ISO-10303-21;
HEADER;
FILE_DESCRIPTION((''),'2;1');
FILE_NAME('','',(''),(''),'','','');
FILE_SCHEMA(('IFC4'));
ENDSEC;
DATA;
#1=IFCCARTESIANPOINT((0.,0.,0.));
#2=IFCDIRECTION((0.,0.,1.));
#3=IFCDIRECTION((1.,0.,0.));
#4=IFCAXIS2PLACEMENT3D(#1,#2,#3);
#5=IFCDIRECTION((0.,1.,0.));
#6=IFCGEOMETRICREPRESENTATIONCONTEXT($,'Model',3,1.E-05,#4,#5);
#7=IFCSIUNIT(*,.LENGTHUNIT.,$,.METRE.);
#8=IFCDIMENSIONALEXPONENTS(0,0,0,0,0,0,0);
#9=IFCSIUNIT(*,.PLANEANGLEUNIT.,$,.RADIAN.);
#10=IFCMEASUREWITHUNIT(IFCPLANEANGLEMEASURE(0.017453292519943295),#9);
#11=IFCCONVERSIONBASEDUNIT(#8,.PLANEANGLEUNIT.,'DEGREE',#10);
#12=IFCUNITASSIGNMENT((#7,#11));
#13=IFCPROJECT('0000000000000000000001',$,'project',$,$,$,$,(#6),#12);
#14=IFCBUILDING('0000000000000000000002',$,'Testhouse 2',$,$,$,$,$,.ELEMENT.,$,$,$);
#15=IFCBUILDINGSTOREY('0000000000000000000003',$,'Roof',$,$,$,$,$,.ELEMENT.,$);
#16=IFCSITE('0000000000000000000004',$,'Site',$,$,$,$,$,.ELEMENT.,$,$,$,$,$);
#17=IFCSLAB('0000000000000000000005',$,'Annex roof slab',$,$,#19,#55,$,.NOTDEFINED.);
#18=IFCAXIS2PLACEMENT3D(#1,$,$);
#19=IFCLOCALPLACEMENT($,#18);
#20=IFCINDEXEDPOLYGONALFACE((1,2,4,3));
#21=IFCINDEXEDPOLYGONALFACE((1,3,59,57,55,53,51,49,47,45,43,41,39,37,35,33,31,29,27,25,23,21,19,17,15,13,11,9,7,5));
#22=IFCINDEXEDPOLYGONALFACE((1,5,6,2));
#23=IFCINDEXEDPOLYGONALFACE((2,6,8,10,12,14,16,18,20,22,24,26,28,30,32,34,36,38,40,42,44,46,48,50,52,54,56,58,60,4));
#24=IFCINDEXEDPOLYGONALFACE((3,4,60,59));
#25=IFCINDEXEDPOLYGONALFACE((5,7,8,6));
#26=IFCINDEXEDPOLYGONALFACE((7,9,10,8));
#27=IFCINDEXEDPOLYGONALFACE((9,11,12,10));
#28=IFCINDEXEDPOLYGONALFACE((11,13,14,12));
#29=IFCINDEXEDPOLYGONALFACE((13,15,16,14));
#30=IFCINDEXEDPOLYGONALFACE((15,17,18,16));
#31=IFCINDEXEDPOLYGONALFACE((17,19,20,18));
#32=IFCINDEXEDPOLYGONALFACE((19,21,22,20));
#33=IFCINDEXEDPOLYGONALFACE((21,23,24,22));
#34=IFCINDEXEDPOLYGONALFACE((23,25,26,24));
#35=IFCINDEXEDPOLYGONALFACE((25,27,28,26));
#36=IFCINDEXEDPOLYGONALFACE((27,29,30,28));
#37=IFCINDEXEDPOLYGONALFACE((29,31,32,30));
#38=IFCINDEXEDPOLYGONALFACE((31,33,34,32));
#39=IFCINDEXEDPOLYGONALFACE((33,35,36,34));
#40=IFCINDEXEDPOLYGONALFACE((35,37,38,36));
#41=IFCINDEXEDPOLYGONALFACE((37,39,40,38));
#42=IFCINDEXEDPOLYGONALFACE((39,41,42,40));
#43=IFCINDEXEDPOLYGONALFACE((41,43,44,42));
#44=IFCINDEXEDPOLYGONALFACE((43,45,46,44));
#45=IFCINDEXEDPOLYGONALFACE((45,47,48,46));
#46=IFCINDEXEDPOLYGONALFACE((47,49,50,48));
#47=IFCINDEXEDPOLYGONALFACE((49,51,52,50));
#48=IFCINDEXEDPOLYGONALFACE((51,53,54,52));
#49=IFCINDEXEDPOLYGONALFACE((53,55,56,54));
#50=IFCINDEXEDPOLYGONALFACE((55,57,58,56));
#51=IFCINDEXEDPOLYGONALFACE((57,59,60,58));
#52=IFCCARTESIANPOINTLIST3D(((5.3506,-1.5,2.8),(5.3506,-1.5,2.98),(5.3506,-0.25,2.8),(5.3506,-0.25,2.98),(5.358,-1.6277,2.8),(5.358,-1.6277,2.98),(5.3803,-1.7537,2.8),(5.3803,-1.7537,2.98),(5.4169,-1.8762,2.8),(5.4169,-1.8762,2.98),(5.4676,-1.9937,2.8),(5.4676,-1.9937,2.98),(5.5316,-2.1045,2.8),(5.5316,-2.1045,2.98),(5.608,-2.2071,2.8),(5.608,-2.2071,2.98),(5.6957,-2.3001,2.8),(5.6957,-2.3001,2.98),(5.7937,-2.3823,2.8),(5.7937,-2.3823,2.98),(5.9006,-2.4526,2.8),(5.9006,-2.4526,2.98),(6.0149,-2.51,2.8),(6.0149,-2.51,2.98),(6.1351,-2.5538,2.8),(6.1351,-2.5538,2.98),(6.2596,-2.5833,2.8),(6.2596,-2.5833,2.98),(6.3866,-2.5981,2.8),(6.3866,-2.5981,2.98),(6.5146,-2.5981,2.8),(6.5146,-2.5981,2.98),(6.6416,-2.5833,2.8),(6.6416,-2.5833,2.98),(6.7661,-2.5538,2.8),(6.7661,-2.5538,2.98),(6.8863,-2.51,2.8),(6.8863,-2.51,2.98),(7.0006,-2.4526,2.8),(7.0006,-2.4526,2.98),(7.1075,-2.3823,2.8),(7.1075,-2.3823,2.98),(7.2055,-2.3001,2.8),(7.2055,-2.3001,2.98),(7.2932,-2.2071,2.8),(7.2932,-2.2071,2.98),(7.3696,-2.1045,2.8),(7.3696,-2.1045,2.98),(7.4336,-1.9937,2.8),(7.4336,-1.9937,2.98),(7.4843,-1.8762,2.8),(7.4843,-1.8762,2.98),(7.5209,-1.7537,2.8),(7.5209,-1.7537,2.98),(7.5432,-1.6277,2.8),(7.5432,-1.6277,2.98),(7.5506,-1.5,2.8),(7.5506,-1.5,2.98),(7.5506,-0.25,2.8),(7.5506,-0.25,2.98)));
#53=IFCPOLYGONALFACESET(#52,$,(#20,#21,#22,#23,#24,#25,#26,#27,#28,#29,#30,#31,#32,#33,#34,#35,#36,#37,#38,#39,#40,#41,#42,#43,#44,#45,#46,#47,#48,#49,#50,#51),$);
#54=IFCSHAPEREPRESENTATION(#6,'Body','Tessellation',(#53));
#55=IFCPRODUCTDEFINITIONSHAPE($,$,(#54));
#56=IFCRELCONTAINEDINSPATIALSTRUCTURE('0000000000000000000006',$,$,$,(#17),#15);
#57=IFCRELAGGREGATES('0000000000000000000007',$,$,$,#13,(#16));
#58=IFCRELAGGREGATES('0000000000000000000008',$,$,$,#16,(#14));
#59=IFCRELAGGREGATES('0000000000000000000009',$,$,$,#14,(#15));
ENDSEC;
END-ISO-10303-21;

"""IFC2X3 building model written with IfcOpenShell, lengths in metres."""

from ifc_helpers import new_model, entity, si_unit, converted_unit, direction, frame, frame_2d, origin_with_axes, place, context, project, spatial, polyline, circle_curve, parameter, trimmed, segment, composite_curve, outline, extrude, element, save


model = new_model("IFC2X3")

# Units and contexts
model_context = context("Model", 3, precision=1e-05, world=origin_with_axes(), true_north=direction((0.0, 1.0, 0.0)))
ifc_project = project(units=[si_unit("LENGTHUNIT", "METRE"), converted_unit("PLANEANGLEUNIT", "DEGREE", entity("IfcPlaneAngleMeasure", 0.017453292519943295), si_unit("PLANEANGLEUNIT", "RADIAN"), dimensions=[0, 0, 0, 0, 0, 0, 0])], contexts=[model_context])

# Site, building, storey
site = spatial("IfcSite", under=ifc_project, Name="Site", CompositionType="ELEMENT")
building = spatial("IfcBuilding", under=site, Name="Testhouse 2", CompositionType="ELEMENT")
storey = spatial("IfcBuildingStorey", under=building, Name="Roof", CompositionType="ELEMENT")

# Slab
slab_placement = place(None, origin_with_axes())
element("IfcSlab", 1, at=slab_placement, inside=storey, Name="Annex roof slab", PredefinedType="NOTDEFINED", context=model_context, shape_type="SweptSolid", body=[
    extrude(outline(composite_curve([segment(polyline([(5.3506, -0.25), (5.3506, -1.5)]), True, "CONTINUOUS"), segment(trimmed(circle_curve(frame_2d((6.4506, -1.5), x_axis=(1.0, 0.0)), 1.1), [parameter(180.0)], [parameter(0.0)], True, "PARAMETER"), True, "CONTINUOUS"), segment(polyline([(7.5506, -1.5), (7.5506, -0.25)]), True, "CONTINUOUS"), segment(polyline([(7.5506, -0.25), (5.3506, -0.25)]), True, "CONTINUOUS")], self_intersect=False)), frame((0.0, 0.0, 2.8), z_axis=(0.0, 0.0, 1.0), x_axis=(1.0, 0.0, 0.0)), (0.0, 0.0, 1.0), 0.18),
])

save(model, "model.ifc")
